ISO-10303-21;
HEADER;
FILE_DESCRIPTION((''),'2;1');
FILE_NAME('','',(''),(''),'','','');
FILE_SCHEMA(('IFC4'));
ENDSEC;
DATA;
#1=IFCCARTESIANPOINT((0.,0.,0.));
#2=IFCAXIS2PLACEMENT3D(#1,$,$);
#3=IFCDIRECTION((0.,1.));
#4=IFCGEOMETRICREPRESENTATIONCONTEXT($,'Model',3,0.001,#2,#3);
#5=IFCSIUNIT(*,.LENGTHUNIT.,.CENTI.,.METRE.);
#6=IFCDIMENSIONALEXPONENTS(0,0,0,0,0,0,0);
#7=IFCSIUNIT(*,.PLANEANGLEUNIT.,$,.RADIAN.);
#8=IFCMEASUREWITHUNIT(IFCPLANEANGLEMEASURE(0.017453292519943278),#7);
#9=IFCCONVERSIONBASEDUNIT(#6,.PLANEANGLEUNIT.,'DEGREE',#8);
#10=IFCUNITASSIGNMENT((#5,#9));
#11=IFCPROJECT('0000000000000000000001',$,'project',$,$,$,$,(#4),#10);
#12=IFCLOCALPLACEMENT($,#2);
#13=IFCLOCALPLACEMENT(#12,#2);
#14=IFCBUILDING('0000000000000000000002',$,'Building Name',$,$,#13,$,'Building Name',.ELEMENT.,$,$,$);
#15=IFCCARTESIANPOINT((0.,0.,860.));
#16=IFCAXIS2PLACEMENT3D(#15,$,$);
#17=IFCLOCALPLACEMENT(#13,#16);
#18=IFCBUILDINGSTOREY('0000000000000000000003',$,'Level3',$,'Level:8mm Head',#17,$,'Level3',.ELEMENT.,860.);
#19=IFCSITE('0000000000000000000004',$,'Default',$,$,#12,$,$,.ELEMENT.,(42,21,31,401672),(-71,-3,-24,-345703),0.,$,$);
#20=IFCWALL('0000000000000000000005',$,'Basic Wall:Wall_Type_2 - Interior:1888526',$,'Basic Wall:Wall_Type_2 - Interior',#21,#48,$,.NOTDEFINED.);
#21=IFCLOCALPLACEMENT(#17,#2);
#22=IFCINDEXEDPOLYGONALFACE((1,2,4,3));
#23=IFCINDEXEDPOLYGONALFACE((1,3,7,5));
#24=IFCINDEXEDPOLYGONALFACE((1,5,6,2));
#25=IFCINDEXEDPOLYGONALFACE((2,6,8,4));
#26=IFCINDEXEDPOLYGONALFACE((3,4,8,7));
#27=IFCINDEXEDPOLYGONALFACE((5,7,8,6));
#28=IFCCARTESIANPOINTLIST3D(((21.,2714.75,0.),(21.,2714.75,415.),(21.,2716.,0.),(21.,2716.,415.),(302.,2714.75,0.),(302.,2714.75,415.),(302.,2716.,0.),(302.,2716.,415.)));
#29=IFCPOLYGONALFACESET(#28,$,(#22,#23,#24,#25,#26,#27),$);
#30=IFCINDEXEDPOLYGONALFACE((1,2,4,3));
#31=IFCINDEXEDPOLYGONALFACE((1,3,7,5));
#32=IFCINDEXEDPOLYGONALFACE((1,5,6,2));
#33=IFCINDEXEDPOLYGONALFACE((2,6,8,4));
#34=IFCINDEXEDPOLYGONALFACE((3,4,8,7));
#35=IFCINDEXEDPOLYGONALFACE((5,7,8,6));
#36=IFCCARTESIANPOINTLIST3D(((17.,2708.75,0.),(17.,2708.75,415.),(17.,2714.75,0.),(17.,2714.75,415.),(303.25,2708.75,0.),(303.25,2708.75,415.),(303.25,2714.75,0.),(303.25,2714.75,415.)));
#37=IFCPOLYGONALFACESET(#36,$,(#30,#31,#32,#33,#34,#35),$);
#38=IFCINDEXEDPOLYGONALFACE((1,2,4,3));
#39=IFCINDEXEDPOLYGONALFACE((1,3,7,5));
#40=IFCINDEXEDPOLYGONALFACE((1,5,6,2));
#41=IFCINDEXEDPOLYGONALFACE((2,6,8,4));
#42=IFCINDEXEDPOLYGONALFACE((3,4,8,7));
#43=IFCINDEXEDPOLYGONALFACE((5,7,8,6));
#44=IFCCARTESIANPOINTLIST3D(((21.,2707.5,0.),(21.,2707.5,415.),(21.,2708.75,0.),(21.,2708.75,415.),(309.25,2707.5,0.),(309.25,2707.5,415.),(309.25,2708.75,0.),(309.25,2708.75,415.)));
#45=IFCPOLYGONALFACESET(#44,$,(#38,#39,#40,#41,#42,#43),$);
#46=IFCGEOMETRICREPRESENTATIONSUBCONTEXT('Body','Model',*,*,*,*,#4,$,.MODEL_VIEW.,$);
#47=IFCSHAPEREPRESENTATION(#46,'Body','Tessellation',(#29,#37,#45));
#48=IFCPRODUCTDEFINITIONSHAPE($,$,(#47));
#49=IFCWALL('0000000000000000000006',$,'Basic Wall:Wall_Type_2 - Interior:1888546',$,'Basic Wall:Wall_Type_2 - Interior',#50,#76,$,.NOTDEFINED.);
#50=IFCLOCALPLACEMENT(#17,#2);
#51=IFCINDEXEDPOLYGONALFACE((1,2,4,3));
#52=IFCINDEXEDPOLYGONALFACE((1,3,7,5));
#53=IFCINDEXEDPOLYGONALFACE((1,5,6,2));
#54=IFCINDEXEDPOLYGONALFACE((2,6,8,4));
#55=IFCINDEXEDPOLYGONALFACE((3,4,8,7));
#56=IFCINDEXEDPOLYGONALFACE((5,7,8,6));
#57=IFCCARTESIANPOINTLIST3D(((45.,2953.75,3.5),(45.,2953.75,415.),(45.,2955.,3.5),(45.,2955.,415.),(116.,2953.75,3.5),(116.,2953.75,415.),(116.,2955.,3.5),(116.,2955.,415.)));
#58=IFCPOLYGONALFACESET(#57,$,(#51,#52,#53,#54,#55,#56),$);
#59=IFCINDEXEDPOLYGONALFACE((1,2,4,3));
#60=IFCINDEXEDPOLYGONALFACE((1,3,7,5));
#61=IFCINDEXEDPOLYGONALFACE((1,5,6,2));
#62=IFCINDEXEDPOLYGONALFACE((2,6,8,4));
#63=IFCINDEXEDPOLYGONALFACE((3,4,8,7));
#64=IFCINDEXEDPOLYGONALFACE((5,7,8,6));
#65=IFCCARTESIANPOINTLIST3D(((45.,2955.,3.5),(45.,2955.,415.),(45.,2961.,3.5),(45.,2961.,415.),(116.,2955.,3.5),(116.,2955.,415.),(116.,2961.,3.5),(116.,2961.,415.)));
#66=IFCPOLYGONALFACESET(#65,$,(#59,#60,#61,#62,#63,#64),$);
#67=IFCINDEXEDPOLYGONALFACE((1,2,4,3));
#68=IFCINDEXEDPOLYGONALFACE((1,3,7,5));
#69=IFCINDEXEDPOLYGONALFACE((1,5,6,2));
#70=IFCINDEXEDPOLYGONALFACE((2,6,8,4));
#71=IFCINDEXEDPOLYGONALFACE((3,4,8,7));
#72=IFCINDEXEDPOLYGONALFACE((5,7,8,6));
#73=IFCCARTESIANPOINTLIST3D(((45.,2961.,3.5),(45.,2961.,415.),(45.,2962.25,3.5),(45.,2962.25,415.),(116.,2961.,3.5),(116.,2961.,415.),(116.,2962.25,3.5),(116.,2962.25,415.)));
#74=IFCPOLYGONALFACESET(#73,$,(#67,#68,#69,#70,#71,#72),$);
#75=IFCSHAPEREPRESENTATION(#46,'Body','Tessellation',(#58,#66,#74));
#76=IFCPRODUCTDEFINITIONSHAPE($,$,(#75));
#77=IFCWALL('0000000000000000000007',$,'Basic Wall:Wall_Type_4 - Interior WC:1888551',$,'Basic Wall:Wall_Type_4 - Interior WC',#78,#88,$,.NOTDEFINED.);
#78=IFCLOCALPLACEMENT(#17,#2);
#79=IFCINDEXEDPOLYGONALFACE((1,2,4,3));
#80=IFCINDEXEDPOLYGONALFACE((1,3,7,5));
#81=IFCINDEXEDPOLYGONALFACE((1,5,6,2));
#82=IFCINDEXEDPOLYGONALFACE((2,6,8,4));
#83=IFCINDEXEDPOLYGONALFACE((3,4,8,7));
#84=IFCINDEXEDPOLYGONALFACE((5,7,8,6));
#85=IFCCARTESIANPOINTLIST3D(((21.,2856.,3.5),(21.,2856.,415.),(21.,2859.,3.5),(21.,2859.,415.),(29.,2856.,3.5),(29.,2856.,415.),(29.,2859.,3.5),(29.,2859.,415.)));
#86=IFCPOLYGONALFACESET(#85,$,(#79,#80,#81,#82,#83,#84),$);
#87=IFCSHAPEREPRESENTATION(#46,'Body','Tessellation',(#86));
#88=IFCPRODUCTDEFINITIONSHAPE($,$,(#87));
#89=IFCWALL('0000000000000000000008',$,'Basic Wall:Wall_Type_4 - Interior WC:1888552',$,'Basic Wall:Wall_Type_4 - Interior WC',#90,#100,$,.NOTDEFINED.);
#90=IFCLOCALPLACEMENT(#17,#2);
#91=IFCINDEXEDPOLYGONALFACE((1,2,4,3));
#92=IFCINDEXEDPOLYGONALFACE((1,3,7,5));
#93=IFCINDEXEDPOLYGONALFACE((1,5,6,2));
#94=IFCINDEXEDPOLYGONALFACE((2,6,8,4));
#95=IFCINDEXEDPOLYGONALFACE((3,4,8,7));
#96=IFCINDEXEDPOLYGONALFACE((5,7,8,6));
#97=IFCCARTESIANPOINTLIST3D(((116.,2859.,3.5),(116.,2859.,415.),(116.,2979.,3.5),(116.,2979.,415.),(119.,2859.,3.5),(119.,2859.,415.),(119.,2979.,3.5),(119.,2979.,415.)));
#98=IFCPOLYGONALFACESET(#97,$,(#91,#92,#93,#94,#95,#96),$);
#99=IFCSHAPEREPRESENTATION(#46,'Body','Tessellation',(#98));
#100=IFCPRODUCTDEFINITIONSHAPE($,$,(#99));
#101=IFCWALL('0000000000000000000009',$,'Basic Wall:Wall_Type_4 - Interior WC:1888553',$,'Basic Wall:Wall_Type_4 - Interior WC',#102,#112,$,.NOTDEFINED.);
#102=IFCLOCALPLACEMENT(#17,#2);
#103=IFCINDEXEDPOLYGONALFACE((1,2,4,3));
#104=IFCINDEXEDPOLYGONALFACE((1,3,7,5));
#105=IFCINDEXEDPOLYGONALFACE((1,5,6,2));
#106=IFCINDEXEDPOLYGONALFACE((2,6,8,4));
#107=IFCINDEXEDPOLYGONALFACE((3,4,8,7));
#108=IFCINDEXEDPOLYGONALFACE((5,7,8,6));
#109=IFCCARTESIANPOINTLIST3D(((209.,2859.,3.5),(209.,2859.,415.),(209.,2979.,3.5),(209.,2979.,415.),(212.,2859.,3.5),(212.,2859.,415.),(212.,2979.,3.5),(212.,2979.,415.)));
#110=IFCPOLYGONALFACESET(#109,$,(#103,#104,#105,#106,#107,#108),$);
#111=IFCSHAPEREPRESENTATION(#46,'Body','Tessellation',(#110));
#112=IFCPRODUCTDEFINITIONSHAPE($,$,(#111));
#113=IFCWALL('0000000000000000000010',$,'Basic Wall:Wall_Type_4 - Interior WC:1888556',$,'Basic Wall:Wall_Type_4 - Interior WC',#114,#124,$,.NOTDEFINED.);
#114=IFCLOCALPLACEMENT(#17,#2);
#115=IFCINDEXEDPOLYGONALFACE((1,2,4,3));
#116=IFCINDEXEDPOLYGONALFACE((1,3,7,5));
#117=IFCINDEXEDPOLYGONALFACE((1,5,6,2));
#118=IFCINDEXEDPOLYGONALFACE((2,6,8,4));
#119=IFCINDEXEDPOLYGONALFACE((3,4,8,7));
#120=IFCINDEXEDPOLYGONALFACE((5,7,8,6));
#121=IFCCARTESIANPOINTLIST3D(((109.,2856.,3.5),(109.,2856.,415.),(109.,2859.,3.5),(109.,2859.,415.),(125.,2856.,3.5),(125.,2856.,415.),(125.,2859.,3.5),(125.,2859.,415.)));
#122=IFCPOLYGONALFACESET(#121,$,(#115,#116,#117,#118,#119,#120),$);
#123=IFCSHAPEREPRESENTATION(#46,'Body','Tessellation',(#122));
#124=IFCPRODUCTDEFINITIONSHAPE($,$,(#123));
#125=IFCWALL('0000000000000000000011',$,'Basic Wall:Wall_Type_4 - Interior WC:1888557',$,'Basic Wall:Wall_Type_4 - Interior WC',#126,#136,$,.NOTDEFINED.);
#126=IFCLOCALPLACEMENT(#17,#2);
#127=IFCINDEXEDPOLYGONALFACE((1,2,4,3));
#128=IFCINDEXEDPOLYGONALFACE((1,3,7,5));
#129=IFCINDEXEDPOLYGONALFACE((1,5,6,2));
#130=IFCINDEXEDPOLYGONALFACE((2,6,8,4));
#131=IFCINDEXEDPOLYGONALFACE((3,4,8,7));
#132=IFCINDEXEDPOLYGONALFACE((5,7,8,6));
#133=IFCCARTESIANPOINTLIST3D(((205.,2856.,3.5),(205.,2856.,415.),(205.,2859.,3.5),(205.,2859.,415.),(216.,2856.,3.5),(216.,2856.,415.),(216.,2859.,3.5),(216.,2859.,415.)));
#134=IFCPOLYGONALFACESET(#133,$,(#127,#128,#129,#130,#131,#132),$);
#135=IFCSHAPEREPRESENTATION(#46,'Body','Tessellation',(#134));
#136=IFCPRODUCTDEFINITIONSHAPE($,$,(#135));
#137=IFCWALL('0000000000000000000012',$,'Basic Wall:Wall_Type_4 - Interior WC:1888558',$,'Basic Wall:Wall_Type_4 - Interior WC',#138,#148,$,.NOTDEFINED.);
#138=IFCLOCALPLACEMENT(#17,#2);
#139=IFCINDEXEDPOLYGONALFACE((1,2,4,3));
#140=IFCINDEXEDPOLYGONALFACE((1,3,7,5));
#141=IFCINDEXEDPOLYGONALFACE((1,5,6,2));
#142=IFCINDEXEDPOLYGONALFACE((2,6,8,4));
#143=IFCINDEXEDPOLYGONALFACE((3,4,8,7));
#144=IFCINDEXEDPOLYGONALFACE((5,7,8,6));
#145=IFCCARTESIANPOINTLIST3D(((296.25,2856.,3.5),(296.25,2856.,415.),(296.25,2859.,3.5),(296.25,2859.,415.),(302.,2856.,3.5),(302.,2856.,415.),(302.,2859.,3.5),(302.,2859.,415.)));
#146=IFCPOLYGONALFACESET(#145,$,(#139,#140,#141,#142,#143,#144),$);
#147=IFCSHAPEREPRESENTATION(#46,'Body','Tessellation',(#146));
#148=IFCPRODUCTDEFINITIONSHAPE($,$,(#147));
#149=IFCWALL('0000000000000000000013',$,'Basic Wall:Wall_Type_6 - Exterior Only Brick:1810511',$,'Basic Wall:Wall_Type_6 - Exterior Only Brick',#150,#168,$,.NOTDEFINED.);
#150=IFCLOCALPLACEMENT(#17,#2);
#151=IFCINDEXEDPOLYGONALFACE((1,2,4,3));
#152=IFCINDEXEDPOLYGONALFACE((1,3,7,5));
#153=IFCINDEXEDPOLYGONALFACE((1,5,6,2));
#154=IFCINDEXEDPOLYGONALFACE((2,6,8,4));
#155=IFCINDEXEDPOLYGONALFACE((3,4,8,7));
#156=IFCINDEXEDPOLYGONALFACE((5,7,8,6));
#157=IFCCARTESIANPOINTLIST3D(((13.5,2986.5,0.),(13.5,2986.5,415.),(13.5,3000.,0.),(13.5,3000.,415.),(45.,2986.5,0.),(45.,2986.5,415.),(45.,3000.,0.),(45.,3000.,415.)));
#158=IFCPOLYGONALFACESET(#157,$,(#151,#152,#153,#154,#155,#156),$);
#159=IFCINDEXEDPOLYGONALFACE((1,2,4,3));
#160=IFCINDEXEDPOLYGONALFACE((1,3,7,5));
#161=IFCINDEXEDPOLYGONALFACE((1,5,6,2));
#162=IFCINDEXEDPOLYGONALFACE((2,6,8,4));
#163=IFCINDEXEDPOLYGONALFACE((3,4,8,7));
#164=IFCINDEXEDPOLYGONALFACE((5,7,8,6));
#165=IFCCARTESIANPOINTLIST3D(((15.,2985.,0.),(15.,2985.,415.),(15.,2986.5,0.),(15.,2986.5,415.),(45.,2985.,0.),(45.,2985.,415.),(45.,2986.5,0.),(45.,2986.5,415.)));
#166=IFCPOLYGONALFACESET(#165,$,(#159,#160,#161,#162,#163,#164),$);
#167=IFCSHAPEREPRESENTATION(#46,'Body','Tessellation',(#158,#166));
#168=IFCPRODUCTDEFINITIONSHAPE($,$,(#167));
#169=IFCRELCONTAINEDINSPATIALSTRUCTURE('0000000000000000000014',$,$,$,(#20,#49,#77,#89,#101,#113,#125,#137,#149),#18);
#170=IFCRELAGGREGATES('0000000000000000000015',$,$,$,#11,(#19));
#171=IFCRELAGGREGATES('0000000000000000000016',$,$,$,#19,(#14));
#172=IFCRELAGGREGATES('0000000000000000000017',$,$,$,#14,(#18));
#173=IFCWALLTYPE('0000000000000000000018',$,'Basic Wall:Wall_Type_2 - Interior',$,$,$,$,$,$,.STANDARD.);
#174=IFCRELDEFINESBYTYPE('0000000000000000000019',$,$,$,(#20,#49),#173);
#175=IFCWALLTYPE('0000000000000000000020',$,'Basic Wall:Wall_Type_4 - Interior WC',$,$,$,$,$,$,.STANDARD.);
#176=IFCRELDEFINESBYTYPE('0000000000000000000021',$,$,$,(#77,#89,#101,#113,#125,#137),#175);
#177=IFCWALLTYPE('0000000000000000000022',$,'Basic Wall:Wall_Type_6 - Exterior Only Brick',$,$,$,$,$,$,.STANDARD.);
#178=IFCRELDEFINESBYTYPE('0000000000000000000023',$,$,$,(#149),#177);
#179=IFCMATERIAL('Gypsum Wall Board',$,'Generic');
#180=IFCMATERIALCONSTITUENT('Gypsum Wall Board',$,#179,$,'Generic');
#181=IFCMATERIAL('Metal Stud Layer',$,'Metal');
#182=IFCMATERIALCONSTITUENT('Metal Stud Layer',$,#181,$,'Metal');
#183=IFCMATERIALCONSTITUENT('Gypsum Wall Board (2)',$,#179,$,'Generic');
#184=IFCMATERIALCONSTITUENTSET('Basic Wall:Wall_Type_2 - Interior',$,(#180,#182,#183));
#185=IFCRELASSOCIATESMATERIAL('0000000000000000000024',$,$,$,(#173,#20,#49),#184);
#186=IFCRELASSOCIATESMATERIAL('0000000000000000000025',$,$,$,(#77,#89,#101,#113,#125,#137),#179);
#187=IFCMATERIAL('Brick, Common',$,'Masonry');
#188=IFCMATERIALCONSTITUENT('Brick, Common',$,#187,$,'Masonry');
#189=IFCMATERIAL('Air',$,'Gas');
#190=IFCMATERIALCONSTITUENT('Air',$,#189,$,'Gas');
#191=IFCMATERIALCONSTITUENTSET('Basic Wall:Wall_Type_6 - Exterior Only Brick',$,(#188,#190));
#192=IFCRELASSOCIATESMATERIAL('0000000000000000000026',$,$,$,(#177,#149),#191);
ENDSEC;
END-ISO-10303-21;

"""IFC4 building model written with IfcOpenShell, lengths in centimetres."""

from ifc_helpers import new_model, entity, si_unit, converted_unit, direction, frame, origin, place, context, subcontext, project, spatial, indexed_curve, outline, extrude, material, constituent, constituent_set, type_object, element, save


model = new_model("IFC4")

# Units and contexts
model_context = context("Model", 3, precision=0.001, world=origin(), true_north=direction((0.0, 1.0)))
body_context = subcontext(model_context, "Body", "Model", "MODEL_VIEW")
ifc_project = project(units=[si_unit("LENGTHUNIT", "METRE", prefix="CENTI"), converted_unit("PLANEANGLEUNIT", "DEGREE", entity("IfcPlaneAngleMeasure", 0.017453292519943278), si_unit("PLANEANGLEUNIT", "RADIAN"), dimensions=[0, 0, 0, 0, 0, 0, 0])], contexts=[model_context])

# Site, building, storey
site_placement = place(None, origin())
site = spatial("IfcSite", under=ifc_project, at=site_placement, Name="Default", CompositionType="ELEMENT", RefLatitude=(42, 21, 31, 401672), RefLongitude=(-71, -3, -24, -345703), RefElevation=0.0)
building_placement = place(site_placement, origin())
building = spatial("IfcBuilding", under=site, at=building_placement, Name="Building Name", LongName="Building Name", CompositionType="ELEMENT")
storey_placement = place(building_placement, frame((0.0, 0.0, 860.0)))
storey = spatial("IfcBuildingStorey", under=building, at=storey_placement, Name="Level3", ObjectType="Level:8mm Head", LongName="Level3", CompositionType="ELEMENT", Elevation=860.0)

# Shared definitions
ifc_material_1 = material(Name="Brick, Common", Category="Masonry")
ifc_material_2 = material(Name="Air", Category="Gas")
ifc_material_3 = material(Name="Metal Stud Layer", Category="Metal")
ifc_material_4 = material(Name="Gypsum Wall Board", Category="Generic")

# Walls
ifc_constituent_1 = constituent(ifc_material_4, Name="Gypsum Wall Board", Category="Generic")
ifc_constituent_2 = constituent(ifc_material_3, Name="Metal Stud Layer", Category="Metal")
ifc_constituent_3 = constituent(ifc_material_4, Name="Gypsum Wall Board (2)", Category="Generic")
ifc_constituent_set_1 = constituent_set(constituents=[ifc_constituent_1, ifc_constituent_2, ifc_constituent_3], Name="Basic Wall:Wall_Type_2 - Interior")
wall_type_1 = type_object("IfcWallType", Name="Basic Wall:Wall_Type_2 - Interior", PredefinedType="STANDARD", material=ifc_constituent_set_1)
wall_1_placement = place(storey_placement, frame((302.0, 2711.75, 0.0), z_axis=(0.0, 0.0, 1.0), x_axis=(-1.0, 0.0, 0.0)))
element("IfcWall", 1, at=wall_1_placement, inside=storey, type_object=wall_type_1, material=ifc_constituent_set_1, Name="Basic Wall:Wall_Type_2 - Interior:1888526", ObjectType="Basic Wall:Wall_Type_2 - Interior", PredefinedType="NOTDEFINED", context=body_context, shape_type="SweptSolid", body=[
    extrude(outline(indexed_curve([(-0.63, -140.5), (0.62, -140.5), (0.63, 140.5), (-0.62, 140.5), (-0.63, -140.5)], self_intersect=False)), frame((140.5, -3.63, 0.0), z_axis=(0.0, 0.0, 1.0), x_axis=(0.0, 1.0, 0.0)), (0.0, 0.0, 1.0), 415.0),
    extrude(outline(indexed_curve([(-143.12, -3.0), (143.12, -3.0), (143.12, 3.0), (-143.12, 3.0), (-143.12, -3.0)], self_intersect=False)), frame((141.87, 0.0, 0.0)), (0.0, 0.0, 1.0), 415.0),
    extrude(outline(indexed_curve([(-0.63, -144.12), (0.62, -144.12), (0.63, 144.12), (-0.62, 144.12), (-0.63, -144.12)], self_intersect=False)), frame((136.87, 3.63, 0.0), z_axis=(0.0, 0.0, 1.0), x_axis=(0.0, -1.0, 0.0)), (0.0, 0.0, 1.0), 415.0),
])
wall_2_placement = place(storey_placement, frame((45.0, 2958.0, 3.5)))
element("IfcWall", 2, at=wall_2_placement, inside=storey, type_object=wall_type_1, material=ifc_constituent_set_1, Name="Basic Wall:Wall_Type_2 - Interior:1888546", ObjectType="Basic Wall:Wall_Type_2 - Interior", PredefinedType="NOTDEFINED", context=body_context, shape_type="SweptSolid", body=[
    extrude(outline(indexed_curve([(-0.62, -35.5), (0.62, -35.5), (0.63, 35.5), (-0.62, 35.5), (-0.62, -35.5)], self_intersect=False)), frame((35.5, -3.63, 0.0), z_axis=(0.0, 0.0, 1.0), x_axis=(0.0, 1.0, 0.0)), (0.0, 0.0, 1.0), 411.5),
    extrude(outline(indexed_curve([(-35.5, -3.0), (35.5, -3.0), (35.5, 3.0), (-35.5, 3.0), (-35.5, -3.0)], self_intersect=False)), frame((35.5, 0.0, 0.0)), (0.0, 0.0, 1.0), 411.5),
    extrude(outline(indexed_curve([(-0.62, -35.5), (0.63, -35.5), (0.63, 35.5), (-0.62, 35.5), (-0.62, -35.5)], self_intersect=False)), frame((35.5, 3.63, 0.0), z_axis=(0.0, 0.0, 1.0), x_axis=(0.0, -1.0, 0.0)), (0.0, 0.0, 1.0), 411.5),
])
wall_type_2 = type_object("IfcWallType", Name="Basic Wall:Wall_Type_4 - Interior WC", PredefinedType="STANDARD")
wall_3_placement = place(storey_placement, frame((21.0, 2857.5, 3.5)))
element("IfcWall", 3, at=wall_3_placement, inside=storey, type_object=wall_type_2, material=ifc_material_4, Name="Basic Wall:Wall_Type_4 - Interior WC:1888551", ObjectType="Basic Wall:Wall_Type_4 - Interior WC", PredefinedType="NOTDEFINED", context=body_context, shape_type="SweptSolid", body=[
    extrude(outline(indexed_curve([(8.0, 1.5), (0.0, 1.5), (0.0, -1.5), (8.0, -1.5), (8.0, 1.5)], self_intersect=False)), origin(), (0.0, 0.0, 1.0), 411.5),
])
wall_4_placement = place(storey_placement, frame((117.5, 2859.0, 3.5), z_axis=(0.0, 0.0, 1.0), x_axis=(0.0, 1.0, 0.0)))
element("IfcWall", 4, at=wall_4_placement, inside=storey, type_object=wall_type_2, material=ifc_material_4, Name="Basic Wall:Wall_Type_4 - Interior WC:1888552", ObjectType="Basic Wall:Wall_Type_4 - Interior WC", PredefinedType="NOTDEFINED", context=body_context, shape_type="SweptSolid", body=[
    extrude(outline(indexed_curve([(120.0, 1.5), (0.0, 1.5), (0.0, -1.5), (120.0, -1.5), (120.0, 1.5)], self_intersect=False)), origin(), (0.0, 0.0, 1.0), 411.5),
])
wall_5_placement = place(storey_placement, frame((210.5, 2859.0, 3.5), z_axis=(0.0, 0.0, 1.0), x_axis=(0.0, 1.0, 0.0)))
element("IfcWall", 5, at=wall_5_placement, inside=storey, type_object=wall_type_2, material=ifc_material_4, Name="Basic Wall:Wall_Type_4 - Interior WC:1888553", ObjectType="Basic Wall:Wall_Type_4 - Interior WC", PredefinedType="NOTDEFINED", context=body_context, shape_type="SweptSolid", body=[
    extrude(outline(indexed_curve([(120.0, 1.5), (0.0, 1.5), (0.0, -1.5), (120.0, -1.5), (120.0, 1.5)], self_intersect=False)), origin(), (0.0, 0.0, 1.0), 411.5),
])
wall_6_placement = place(storey_placement, frame((109.0, 2857.5, 3.5)))
element("IfcWall", 6, at=wall_6_placement, inside=storey, type_object=wall_type_2, material=ifc_material_4, Name="Basic Wall:Wall_Type_4 - Interior WC:1888556", ObjectType="Basic Wall:Wall_Type_4 - Interior WC", PredefinedType="NOTDEFINED", context=body_context, shape_type="SweptSolid", body=[
    extrude(outline(indexed_curve([(16.0, 1.5), (0.0, 1.5), (0.0, -1.5), (16.0, -1.5), (16.0, 1.5)], self_intersect=False)), origin(), (0.0, 0.0, 1.0), 411.5),
])
wall_7_placement = place(storey_placement, frame((205.0, 2857.5, 3.5)))
element("IfcWall", 7, at=wall_7_placement, inside=storey, type_object=wall_type_2, material=ifc_material_4, Name="Basic Wall:Wall_Type_4 - Interior WC:1888557", ObjectType="Basic Wall:Wall_Type_4 - Interior WC", PredefinedType="NOTDEFINED", context=body_context, shape_type="SweptSolid", body=[
    extrude(outline(indexed_curve([(11.0, 1.5), (0.0, 1.5), (0.0, -1.5), (11.0, -1.5), (11.0, 1.5)], self_intersect=False)), origin(), (0.0, 0.0, 1.0), 411.5),
])
wall_8_placement = place(storey_placement, frame((296.25, 2857.5, 3.5)))
element("IfcWall", 8, at=wall_8_placement, inside=storey, type_object=wall_type_2, material=ifc_material_4, Name="Basic Wall:Wall_Type_4 - Interior WC:1888558", ObjectType="Basic Wall:Wall_Type_4 - Interior WC", PredefinedType="NOTDEFINED", context=body_context, shape_type="SweptSolid", body=[
    extrude(outline(indexed_curve([(5.75, 1.5), (0.0, 1.5), (0.0, -1.5), (5.75, -1.5), (5.75, 1.5)], self_intersect=False)), origin(), (0.0, 0.0, 1.0), 411.5),
])
ifc_constituent_4 = constituent(ifc_material_1, Name="Brick, Common", Category="Masonry")
ifc_constituent_5 = constituent(ifc_material_2, Name="Air", Category="Gas")
ifc_constituent_set_2 = constituent_set(constituents=[ifc_constituent_4, ifc_constituent_5], Name="Basic Wall:Wall_Type_6 - Exterior Only Brick")
wall_type_3 = type_object("IfcWallType", Name="Basic Wall:Wall_Type_6 - Exterior Only Brick", PredefinedType="STANDARD", material=ifc_constituent_set_2)
wall_9_placement = place(storey_placement, frame((15.0, 2992.5, 0.0)))
element("IfcWall", 9, at=wall_9_placement, inside=storey, type_object=wall_type_3, material=ifc_constituent_set_2, Name="Basic Wall:Wall_Type_6 - Exterior Only Brick:1810511", ObjectType="Basic Wall:Wall_Type_6 - Exterior Only Brick", PredefinedType="NOTDEFINED", context=body_context, shape_type="SweptSolid", body=[
    extrude(outline(indexed_curve([(-6.75, -15.75), (6.75, -15.75), (6.75, 15.75), (-6.75, 15.75), (-6.75, -15.75)], self_intersect=False)), frame((14.25, 0.75, 0.0), z_axis=(0.0, 0.0, 1.0), x_axis=(0.0, -1.0, 0.0)), (0.0, 0.0, 1.0), 415.0),
    extrude(outline(indexed_curve([(-0.75, -15.0), (0.75, -15.0), (0.75, 15.0), (-0.75, 15.0), (-0.75, -15.0)], self_intersect=False)), frame((15.0, -6.75, 0.0), z_axis=(0.0, 0.0, 1.0), x_axis=(0.0, 1.0, 0.0)), (0.0, 0.0, 1.0), 415.0),
])

save(model, "model.ifc")
